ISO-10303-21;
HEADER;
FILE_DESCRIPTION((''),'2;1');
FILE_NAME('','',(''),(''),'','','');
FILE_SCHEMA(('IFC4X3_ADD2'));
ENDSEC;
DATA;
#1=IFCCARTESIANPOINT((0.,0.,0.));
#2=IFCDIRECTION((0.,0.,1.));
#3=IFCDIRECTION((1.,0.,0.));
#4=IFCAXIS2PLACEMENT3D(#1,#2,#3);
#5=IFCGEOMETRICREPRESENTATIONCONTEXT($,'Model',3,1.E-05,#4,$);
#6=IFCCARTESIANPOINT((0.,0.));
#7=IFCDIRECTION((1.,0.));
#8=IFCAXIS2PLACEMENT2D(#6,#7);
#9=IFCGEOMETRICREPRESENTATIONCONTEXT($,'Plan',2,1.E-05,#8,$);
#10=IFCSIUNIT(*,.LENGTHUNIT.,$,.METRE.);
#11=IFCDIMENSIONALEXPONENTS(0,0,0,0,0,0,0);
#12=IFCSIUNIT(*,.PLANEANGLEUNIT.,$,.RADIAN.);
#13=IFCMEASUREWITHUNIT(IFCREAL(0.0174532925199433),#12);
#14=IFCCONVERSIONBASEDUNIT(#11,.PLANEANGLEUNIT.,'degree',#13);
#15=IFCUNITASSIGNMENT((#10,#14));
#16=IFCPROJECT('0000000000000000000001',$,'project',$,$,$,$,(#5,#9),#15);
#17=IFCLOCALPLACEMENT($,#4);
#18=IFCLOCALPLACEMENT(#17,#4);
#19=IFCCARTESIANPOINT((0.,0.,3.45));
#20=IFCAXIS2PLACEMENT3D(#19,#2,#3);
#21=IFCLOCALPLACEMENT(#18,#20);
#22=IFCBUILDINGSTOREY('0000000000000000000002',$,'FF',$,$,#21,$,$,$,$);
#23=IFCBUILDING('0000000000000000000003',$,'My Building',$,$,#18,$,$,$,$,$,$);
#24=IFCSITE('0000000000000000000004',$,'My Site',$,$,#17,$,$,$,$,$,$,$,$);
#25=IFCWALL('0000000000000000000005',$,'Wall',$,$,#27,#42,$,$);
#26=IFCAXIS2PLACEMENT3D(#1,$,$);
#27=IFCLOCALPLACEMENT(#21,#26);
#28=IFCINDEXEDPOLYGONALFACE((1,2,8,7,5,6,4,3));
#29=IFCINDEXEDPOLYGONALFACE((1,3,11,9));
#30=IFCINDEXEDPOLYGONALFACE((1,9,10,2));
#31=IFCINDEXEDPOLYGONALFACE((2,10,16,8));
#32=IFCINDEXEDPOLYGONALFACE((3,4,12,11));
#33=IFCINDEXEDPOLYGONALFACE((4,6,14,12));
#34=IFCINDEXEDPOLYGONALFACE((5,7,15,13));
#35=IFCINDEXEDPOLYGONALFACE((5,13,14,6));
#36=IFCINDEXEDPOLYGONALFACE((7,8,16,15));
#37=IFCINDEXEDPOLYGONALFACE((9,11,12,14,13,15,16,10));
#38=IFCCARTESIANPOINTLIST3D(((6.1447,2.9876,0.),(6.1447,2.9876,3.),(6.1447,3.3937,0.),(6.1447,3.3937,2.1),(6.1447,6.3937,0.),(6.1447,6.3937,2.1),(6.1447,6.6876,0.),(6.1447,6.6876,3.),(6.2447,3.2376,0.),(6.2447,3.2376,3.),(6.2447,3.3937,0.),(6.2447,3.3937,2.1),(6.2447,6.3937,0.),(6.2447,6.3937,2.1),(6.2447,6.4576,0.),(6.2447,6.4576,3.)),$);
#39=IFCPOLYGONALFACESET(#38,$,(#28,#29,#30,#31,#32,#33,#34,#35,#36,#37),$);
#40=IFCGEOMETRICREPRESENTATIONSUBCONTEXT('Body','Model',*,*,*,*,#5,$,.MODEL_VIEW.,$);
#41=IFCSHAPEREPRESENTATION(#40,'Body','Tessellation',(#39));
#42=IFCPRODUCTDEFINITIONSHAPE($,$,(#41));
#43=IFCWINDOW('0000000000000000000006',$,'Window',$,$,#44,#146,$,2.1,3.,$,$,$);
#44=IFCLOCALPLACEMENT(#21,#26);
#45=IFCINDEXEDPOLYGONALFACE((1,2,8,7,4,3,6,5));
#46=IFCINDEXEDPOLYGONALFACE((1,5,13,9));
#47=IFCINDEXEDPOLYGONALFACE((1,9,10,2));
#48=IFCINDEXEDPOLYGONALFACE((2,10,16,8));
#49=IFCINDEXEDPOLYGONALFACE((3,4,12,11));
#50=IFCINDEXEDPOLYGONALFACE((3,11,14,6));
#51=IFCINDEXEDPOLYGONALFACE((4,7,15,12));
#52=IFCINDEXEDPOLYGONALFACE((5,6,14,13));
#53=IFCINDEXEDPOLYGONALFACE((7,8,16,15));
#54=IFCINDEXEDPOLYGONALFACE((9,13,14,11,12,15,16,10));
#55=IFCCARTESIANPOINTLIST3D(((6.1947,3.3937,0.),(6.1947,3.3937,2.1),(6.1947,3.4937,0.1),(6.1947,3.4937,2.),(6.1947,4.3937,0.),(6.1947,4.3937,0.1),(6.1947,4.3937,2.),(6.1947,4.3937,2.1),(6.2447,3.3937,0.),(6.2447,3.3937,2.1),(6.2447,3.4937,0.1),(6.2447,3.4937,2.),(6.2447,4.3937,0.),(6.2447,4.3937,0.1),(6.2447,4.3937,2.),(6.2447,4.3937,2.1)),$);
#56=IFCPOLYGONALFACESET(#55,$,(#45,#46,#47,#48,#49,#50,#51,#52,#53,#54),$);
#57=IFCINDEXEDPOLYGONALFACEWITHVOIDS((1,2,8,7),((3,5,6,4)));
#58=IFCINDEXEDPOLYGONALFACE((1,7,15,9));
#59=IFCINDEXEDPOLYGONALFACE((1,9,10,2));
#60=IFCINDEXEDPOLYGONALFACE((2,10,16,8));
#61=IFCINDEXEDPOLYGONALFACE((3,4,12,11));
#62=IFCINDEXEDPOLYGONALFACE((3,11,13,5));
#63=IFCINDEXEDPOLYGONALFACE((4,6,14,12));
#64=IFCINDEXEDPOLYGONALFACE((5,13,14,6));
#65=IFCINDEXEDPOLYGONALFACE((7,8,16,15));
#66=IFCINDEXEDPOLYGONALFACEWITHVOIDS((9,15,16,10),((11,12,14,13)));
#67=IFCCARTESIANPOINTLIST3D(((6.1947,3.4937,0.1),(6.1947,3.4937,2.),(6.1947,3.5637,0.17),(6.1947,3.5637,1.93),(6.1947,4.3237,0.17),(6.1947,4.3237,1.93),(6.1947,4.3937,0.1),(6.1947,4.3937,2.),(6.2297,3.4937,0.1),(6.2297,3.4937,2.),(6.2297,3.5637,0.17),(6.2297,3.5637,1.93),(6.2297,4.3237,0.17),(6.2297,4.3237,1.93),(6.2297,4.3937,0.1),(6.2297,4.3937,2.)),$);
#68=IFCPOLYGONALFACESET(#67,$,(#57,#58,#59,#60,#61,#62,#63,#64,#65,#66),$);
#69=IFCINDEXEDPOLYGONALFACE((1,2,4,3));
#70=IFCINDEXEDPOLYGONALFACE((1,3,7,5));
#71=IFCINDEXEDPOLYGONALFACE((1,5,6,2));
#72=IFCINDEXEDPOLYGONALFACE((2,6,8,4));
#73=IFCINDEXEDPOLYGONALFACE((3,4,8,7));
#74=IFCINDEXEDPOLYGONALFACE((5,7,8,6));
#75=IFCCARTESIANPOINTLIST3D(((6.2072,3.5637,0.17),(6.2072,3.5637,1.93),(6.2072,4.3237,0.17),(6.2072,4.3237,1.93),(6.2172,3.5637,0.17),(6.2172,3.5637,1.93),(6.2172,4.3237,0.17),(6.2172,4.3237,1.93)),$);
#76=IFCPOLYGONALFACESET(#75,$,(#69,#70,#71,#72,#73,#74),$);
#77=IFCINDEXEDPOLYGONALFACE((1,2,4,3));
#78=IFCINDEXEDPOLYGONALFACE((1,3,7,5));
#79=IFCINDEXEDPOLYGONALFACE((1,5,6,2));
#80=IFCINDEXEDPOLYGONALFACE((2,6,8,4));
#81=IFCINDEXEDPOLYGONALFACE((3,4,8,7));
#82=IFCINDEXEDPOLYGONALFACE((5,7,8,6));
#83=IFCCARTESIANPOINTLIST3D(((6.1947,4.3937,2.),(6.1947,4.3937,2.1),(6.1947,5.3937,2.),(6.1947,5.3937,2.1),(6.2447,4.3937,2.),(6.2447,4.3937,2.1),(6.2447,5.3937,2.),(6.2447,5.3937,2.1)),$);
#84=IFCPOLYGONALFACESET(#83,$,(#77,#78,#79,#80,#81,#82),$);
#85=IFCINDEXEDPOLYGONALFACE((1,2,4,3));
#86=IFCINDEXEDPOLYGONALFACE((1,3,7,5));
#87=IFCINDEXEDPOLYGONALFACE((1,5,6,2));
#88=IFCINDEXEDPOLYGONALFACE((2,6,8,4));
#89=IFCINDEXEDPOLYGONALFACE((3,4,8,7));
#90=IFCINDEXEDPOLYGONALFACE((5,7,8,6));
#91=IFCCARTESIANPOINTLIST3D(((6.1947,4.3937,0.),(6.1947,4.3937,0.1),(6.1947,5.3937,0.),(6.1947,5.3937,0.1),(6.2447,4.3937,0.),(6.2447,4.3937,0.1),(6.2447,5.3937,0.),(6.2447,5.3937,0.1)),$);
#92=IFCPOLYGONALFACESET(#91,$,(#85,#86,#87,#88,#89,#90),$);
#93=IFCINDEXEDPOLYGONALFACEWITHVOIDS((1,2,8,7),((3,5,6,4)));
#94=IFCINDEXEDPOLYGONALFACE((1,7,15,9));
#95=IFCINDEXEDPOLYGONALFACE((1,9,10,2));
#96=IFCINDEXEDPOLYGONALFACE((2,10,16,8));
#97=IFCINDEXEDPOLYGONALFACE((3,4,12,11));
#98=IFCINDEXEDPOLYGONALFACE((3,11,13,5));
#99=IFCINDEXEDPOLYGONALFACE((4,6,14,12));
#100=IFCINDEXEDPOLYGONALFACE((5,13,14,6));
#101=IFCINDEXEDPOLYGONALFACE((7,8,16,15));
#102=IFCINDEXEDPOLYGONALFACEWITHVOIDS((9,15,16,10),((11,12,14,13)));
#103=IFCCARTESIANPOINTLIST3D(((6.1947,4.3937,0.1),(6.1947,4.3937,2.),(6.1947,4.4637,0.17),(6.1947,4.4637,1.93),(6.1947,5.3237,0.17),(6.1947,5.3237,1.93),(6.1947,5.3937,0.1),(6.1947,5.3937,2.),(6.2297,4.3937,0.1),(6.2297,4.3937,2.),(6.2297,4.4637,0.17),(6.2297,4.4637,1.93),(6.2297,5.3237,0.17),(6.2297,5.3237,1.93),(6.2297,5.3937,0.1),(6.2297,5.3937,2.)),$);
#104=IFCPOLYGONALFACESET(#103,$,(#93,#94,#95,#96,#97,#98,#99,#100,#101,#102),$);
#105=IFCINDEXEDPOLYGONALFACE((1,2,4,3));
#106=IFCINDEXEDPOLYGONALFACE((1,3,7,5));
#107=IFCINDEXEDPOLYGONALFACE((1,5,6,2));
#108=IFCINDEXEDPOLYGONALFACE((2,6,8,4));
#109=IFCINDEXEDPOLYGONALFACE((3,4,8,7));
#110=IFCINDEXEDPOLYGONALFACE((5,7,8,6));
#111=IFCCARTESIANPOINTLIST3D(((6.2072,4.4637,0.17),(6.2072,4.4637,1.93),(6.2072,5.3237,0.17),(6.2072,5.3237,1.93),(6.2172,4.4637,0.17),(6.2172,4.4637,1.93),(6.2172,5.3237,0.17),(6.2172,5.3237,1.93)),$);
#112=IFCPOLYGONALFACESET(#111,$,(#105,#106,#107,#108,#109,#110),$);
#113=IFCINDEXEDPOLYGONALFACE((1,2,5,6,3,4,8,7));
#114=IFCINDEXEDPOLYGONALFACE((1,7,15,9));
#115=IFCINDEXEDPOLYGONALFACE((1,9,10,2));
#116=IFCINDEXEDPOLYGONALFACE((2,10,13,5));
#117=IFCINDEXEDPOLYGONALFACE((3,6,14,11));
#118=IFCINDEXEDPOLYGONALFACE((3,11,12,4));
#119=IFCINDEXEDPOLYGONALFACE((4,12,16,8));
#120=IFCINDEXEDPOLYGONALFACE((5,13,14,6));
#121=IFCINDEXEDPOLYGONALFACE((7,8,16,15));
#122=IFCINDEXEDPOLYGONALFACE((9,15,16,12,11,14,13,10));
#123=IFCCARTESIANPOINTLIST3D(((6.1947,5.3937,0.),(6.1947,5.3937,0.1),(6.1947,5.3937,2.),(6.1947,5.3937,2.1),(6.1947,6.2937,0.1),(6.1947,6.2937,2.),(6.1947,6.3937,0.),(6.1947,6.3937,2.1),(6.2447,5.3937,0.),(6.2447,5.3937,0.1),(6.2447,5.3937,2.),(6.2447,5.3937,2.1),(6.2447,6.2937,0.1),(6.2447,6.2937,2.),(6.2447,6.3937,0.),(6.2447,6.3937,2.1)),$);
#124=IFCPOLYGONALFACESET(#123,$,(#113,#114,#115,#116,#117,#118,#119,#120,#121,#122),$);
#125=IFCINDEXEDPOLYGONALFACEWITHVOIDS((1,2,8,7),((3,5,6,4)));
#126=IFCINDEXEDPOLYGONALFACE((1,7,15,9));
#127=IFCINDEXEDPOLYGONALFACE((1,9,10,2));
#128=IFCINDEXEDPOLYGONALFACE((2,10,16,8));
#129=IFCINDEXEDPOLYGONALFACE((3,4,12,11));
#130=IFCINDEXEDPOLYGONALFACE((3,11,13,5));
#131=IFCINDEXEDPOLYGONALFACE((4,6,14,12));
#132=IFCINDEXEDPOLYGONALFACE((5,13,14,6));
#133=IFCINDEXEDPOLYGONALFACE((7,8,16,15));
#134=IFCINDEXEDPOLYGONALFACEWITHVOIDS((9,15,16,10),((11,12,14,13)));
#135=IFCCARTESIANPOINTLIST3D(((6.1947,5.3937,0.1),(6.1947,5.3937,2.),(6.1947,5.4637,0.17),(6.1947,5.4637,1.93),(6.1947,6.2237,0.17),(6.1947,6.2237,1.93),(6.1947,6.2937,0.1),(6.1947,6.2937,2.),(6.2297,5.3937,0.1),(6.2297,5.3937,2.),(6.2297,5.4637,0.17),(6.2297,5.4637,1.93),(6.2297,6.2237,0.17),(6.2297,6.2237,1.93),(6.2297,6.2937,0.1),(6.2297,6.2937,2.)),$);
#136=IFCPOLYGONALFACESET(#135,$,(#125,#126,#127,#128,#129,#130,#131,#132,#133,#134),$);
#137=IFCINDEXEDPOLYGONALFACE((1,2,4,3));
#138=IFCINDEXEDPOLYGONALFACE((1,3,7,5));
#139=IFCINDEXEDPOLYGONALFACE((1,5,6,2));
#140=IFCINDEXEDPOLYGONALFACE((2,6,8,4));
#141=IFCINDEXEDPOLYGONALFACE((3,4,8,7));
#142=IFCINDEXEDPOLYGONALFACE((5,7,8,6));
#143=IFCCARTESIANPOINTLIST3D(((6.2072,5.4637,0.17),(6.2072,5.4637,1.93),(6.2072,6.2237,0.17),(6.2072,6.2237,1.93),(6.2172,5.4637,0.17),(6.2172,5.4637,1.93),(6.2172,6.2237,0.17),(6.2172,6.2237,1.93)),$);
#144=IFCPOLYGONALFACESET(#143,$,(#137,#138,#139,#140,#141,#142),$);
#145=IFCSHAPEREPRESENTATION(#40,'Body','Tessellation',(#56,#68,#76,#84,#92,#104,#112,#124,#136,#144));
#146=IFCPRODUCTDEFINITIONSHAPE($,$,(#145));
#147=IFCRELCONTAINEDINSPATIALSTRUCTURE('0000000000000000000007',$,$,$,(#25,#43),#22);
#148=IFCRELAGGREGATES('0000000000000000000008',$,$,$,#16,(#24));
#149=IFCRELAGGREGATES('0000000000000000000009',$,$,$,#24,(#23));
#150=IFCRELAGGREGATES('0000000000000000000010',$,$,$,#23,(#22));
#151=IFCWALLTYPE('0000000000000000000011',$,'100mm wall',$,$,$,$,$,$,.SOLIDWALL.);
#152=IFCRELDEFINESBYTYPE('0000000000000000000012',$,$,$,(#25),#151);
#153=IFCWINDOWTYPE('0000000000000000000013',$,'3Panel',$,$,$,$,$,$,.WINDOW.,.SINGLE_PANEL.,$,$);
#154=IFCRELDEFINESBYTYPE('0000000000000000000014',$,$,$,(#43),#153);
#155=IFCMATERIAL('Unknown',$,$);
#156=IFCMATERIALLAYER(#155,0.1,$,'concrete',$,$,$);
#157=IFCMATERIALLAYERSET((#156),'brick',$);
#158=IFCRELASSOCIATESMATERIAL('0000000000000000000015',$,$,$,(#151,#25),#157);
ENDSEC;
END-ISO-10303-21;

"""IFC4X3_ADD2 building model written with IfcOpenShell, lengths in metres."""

from ifc_helpers import new_model, entity, si_unit, converted_unit, frame, origin_with_axes, origin_2d_with_axis, place, context, subcontext, project, spatial, line, indexed_curve, outline, extrude, shape, source, transform, mapped, material, layer, layer_set, layer_usage, type_object, type_shapes, element, fill, save


model = new_model("IFC4X3_ADD2")

# Units and contexts
model_context = context("Model", 3, precision=1e-05, world=origin_with_axes())
plan_context = context("Plan", 2, precision=1e-05, world=origin_2d_with_axis())
body_context_1 = subcontext(model_context, "Body", "Model", "MODEL_VIEW")
body_context_2 = subcontext(plan_context, "Body", "Plan", "PLAN_VIEW")
ifc_project = project(units=[si_unit("LENGTHUNIT", "METRE"), converted_unit("PLANEANGLEUNIT", "degree", entity("IfcReal", 0.0174532925199433), si_unit("PLANEANGLEUNIT", "RADIAN"), dimensions=[0, 0, 0, 0, 0, 0, 0])], contexts=[model_context, plan_context])

# Site, building, storey
site_placement = place(None, origin_with_axes())
site = spatial("IfcSite", under=ifc_project, at=site_placement, Name="My Site")
building_placement = place(site_placement, origin_with_axes())
building = spatial("IfcBuilding", under=site, at=building_placement, Name="My Building")
storey_placement = place(building_placement, frame((0.0, 0.0, 3.45), z_axis=(0.0, 0.0, 1.0), x_axis=(1.0, 0.0, 0.0)))
storey = spatial("IfcBuildingStorey", under=building, at=storey_placement, Name="FF")

# Shared definitions
ifc_material = material(Name="Unknown")

# Shared definitions
ifc_layer_1 = layer(ifc_material, 0.1, Name="concrete")
ifc_layer_set_1 = layer_set([ifc_layer_1], Name="brick")
wall_type_1 = type_object("IfcWallType", Name="100mm wall", PredefinedType="SOLIDWALL", material=ifc_layer_set_1)

# Wall, opening, window
ifc_layer_usage_1 = layer_usage(ifc_layer_set_1, "AXIS2", "POSITIVE", 0.0)
wall_1_placement = place(storey_placement, frame((6.2447, 2.9876, 0.0), z_axis=(0.0, 0.0, 1.0), x_axis=(0.0, 1.0, 0.0)))
wall_1 = element("IfcWall", 1, at=wall_1_placement, inside=storey, type_object=wall_type_1, material=ifc_layer_usage_1, Name="Wall", context=body_context_1, shape_type="SweptSolid", body=[
    extrude(outline(indexed_curve([(0.25, 0.0), (0.0, 0.1), (3.7, 0.1), (3.47, 0.0)], segments=[line(1, 2, 3, 4, 1)])), origin_with_axes(), (0.0, 0.0, 1.0), 3.0),
])
shared_shape_1 = source(origin_with_axes(), body_context_1, "Body", "SweptSolid", [
    extrude(outline(indexed_curve([(0.0, 0.0), (3.0, 0.0), (3.0, 2.1), (0.0, 2.1)], segments=[line(1, 2, 3, 4, 1)])), frame((0.0, -0.6, 0.0), z_axis=(0.0, -1.0, 0.0), x_axis=(1.0, 0.0, 0.0)), (0.0, 0.0, -1.0), 1.2),
])
opening_1_placement = place(wall_1_placement, frame((0.4061, 0.0, 0.0), z_axis=(0.0, 0.0, 1.0), x_axis=(1.0, 0.0, 0.0)))
opening_1 = element("IfcOpeningElement", 2, at=opening_1_placement, cuts=wall_1, PredefinedType="OPENING", context=body_context_1, shape_type="MappedRepresentation", body=[
    mapped(shared_shape_1, transform((0.0, 0.0, 0.0), x_axis=(1.0, 0.0, 0.0), y_axis=(0.0, 1.0, 0.0), z_axis=(0.0, 0.0, 1.0), scale=1.0)),
])
window_type = type_object("IfcWindowType", Name="3Panel", PartitioningType="SINGLE_PANEL", PredefinedType="WINDOW")
shared_shape_2 = source(origin_with_axes(), body_context_1, "Body", "SweptSolid", [
    extrude(outline(indexed_curve([(1.0, 0.0), (0.0, 0.0), (0.0, 2.1), (1.0, 2.1), (1.0, 2.0), (0.1, 2.0), (0.1, 0.1), (1.0, 0.1)], segments=[line(1, 2, 3, 4, 5, 6, 7, 8, 1)])), frame((0.0, 0.0, 0.0), z_axis=(0.0, -1.0, 0.0), x_axis=(1.0, 0.0, 0.0)), (0.0, 0.0, -1.0), 0.05),
    extrude(outline(indexed_curve([(0.0, 0.0), (0.9, 0.0), (0.9, 1.9), (0.0, 1.9)], segments=[line(1, 2, 3, 4, 1)]), holes=[indexed_curve([(0.07, 0.07), (0.83, 0.07), (0.83, 1.83), (0.07, 1.83)], segments=[line(1, 2, 3, 4, 1)])]), frame((0.1, 0.015, 0.1), z_axis=(0.0, -1.0, 0.0), x_axis=(1.0, 0.0, 0.0)), (0.0, 0.0, -1.0), 0.035),
    extrude(outline(indexed_curve([(0.07, 0.07), (0.83, 0.07), (0.83, 1.83), (0.07, 1.83)], segments=[line(1, 2, 3, 4, 1)])), frame((0.1, 0.0275, 0.1), z_axis=(0.0, -1.0, 0.0), x_axis=(1.0, 0.0, 0.0)), (0.0, 0.0, -1.0), 0.01),
    extrude(outline(indexed_curve([(0.0, 2.1), (1.0, 2.1), (1.0, 2.0), (0.0, 2.0)], segments=[line(1, 2, 3, 4, 1)])), frame((1.0, 0.0, 0.0), z_axis=(0.0, -1.0, 0.0), x_axis=(1.0, 0.0, 0.0)), (0.0, 0.0, -1.0), 0.05),
    extrude(outline(indexed_curve([(1.0, 0.0), (0.0, 0.0), (0.0, 0.1), (1.0, 0.1)], segments=[line(1, 2, 3, 4, 1)])), frame((1.0, 0.0, 0.0), z_axis=(0.0, -1.0, 0.0), x_axis=(1.0, 0.0, 0.0)), (0.0, 0.0, -1.0), 0.05),
    extrude(outline(indexed_curve([(0.0, 0.0), (1.0, 0.0), (1.0, 1.9), (0.0, 1.9)], segments=[line(1, 2, 3, 4, 1)]), holes=[indexed_curve([(0.07, 0.07), (0.93, 0.07), (0.93, 1.83), (0.07, 1.83)], segments=[line(1, 2, 3, 4, 1)])]), frame((1.0, 0.015, 0.1), z_axis=(0.0, -1.0, 0.0), x_axis=(1.0, 0.0, 0.0)), (0.0, 0.0, -1.0), 0.035),
    extrude(outline(indexed_curve([(0.07, 0.07), (0.93, 0.07), (0.93, 1.83), (0.07, 1.83)], segments=[line(1, 2, 3, 4, 1)])), frame((1.0, 0.0275, 0.1), z_axis=(0.0, -1.0, 0.0), x_axis=(1.0, 0.0, 0.0)), (0.0, 0.0, -1.0), 0.01),
    extrude(outline(indexed_curve([(0.0, 2.1), (1.0, 2.1), (1.0, 0.0), (0.0, 0.0), (0.0, 0.1), (0.9, 0.1), (0.9, 2.0), (0.0, 2.0)], segments=[line(1, 2, 3, 4, 5, 6, 7, 8, 1)])), frame((2.0, 0.0, 0.0), z_axis=(0.0, -1.0, 0.0), x_axis=(1.0, 0.0, 0.0)), (0.0, 0.0, -1.0), 0.05),
    extrude(outline(indexed_curve([(0.0, 0.0), (0.9, 0.0), (0.9, 1.9), (0.0, 1.9)], segments=[line(1, 2, 3, 4, 1)]), holes=[indexed_curve([(0.07, 0.07), (0.83, 0.07), (0.83, 1.83), (0.07, 1.83)], segments=[line(1, 2, 3, 4, 1)])]), frame((2.0, 0.015, 0.1), z_axis=(0.0, -1.0, 0.0), x_axis=(1.0, 0.0, 0.0)), (0.0, 0.0, -1.0), 0.035),
    extrude(outline(indexed_curve([(0.07, 0.07), (0.83, 0.07), (0.83, 1.83), (0.07, 1.83)], segments=[line(1, 2, 3, 4, 1)])), frame((2.0, 0.0275, 0.1), z_axis=(0.0, -1.0, 0.0), x_axis=(1.0, 0.0, 0.0)), (0.0, 0.0, -1.0), 0.01),
])
shared_shape_3 = source(origin_with_axes(), body_context_2, "Body", "Curve2D", [
    entity("IfcIndexedPolyCurve", entity("IfcCartesianPointList2D", [[0.1, 0.0], [1.0, 0.0]])),
    entity("IfcIndexedPolyCurve", entity("IfcCartesianPointList2D", [[0.0, 0.05], [0.1, 0.05], [0.1, 0.0], [0.0, 0.0]]), [entity("IfcLineIndex", [1, 2, 3, 4, 1])]),
    entity("IfcIndexedPolyCurve", entity("IfcCartesianPointList2D", [[1.0, 0.05], [1.0, 0.05], [1.0, 0.0], [1.0, 0.0]])),
    entity("IfcIndexedPolyCurve", entity("IfcCartesianPointList2D", [[0.1, 0.015], [0.17, 0.015], [0.17, 0.05], [0.1, 0.05]]), [entity("IfcLineIndex", [1, 2, 3, 4, 1])]),
    entity("IfcIndexedPolyCurve", entity("IfcCartesianPointList2D", [[1.0, 0.015], [0.93, 0.015], [0.93, 0.05], [1.0, 0.05]]), [entity("IfcLineIndex", [1, 2, 3, 4, 1])]),
    entity("IfcIndexedPolyCurve", entity("IfcCartesianPointList2D", [[0.17, 0.015], [0.93, 0.015]])),
    entity("IfcIndexedPolyCurve", entity("IfcCartesianPointList2D", [[0.17, 0.05], [0.93, 0.05]])),
    entity("IfcIndexedPolyCurve", entity("IfcCartesianPointList2D", [[0.17, 0.0325], [0.93, 0.0325]])),
    entity("IfcIndexedPolyCurve", entity("IfcCartesianPointList2D", [[1.0, 0.0], [2.0, 0.0]])),
    entity("IfcIndexedPolyCurve", entity("IfcCartesianPointList2D", [[1.0, 0.05], [1.0, 0.05], [1.0, 0.0], [1.0, 0.0]])),
    entity("IfcIndexedPolyCurve", entity("IfcCartesianPointList2D", [[2.0, 0.05], [2.0, 0.05], [2.0, 0.0], [2.0, 0.0]])),
    entity("IfcIndexedPolyCurve", entity("IfcCartesianPointList2D", [[1.0, 0.015], [1.07, 0.015], [1.07, 0.05], [1.0, 0.05]]), [entity("IfcLineIndex", [1, 2, 3, 4, 1])]),
    entity("IfcIndexedPolyCurve", entity("IfcCartesianPointList2D", [[2.0, 0.015], [1.93, 0.015], [1.93, 0.05], [2.0, 0.05]]), [entity("IfcLineIndex", [1, 2, 3, 4, 1])]),
    entity("IfcIndexedPolyCurve", entity("IfcCartesianPointList2D", [[1.07, 0.015], [1.93, 0.015]])),
    entity("IfcIndexedPolyCurve", entity("IfcCartesianPointList2D", [[1.07, 0.05], [1.93, 0.05]])),
    entity("IfcIndexedPolyCurve", entity("IfcCartesianPointList2D", [[1.07, 0.0325], [1.93, 0.0325]])),
    entity("IfcIndexedPolyCurve", entity("IfcCartesianPointList2D", [[2.0, 0.0], [2.9, 0.0]])),
    entity("IfcIndexedPolyCurve", entity("IfcCartesianPointList2D", [[2.0, 0.05], [2.0, 0.05], [2.0, 0.0], [2.0, 0.0]])),
    entity("IfcIndexedPolyCurve", entity("IfcCartesianPointList2D", [[3.0, 0.05], [2.9, 0.05], [2.9, 0.0], [3.0, 0.0]]), [entity("IfcLineIndex", [1, 2, 3, 4, 1])]),
    entity("IfcIndexedPolyCurve", entity("IfcCartesianPointList2D", [[2.0, 0.015], [2.07, 0.015], [2.07, 0.05], [2.0, 0.05]]), [entity("IfcLineIndex", [1, 2, 3, 4, 1])]),
    entity("IfcIndexedPolyCurve", entity("IfcCartesianPointList2D", [[2.9, 0.015], [2.83, 0.015], [2.83, 0.05], [2.9, 0.05]]), [entity("IfcLineIndex", [1, 2, 3, 4, 1])]),
    entity("IfcIndexedPolyCurve", entity("IfcCartesianPointList2D", [[2.07, 0.015], [2.83, 0.015]])),
    entity("IfcIndexedPolyCurve", entity("IfcCartesianPointList2D", [[2.07, 0.05], [2.83, 0.05]])),
    entity("IfcIndexedPolyCurve", entity("IfcCartesianPointList2D", [[2.07, 0.0325], [2.83, 0.0325]])),
])
type_shapes(window_type, [shared_shape_2, shared_shape_3])
window_placement = place(opening_1_placement, frame((0.0, 0.0, 0.0), z_axis=(0.0, 0.0, 1.0), x_axis=(1.0, 0.0, 0.0)))
window = element("IfcWindow", 3, at=window_placement, inside=storey, type_object=window_type, Name="Window", OverallHeight=2.1, OverallWidth=3.0, shapes=[
    shape(body_context_1, "Body", "MappedRepresentation", [mapped(shared_shape_2, transform((0.0, 0.0, 0.0), x_axis=(1.0, 0.0, 0.0), y_axis=(0.0, 1.0, 0.0), z_axis=(0.0, 0.0, 1.0), scale=1.0))]),
    shape(body_context_2, "Body", "MappedRepresentation", [mapped(shared_shape_3, transform((0.0, 0.0, 0.0), x_axis=(1.0, 0.0, 0.0), y_axis=(0.0, 1.0, 0.0), z_axis=(0.0, 0.0, 1.0), scale=1.0))]),
])
fill(opening_1, window)

save(model, "model.ifc")
